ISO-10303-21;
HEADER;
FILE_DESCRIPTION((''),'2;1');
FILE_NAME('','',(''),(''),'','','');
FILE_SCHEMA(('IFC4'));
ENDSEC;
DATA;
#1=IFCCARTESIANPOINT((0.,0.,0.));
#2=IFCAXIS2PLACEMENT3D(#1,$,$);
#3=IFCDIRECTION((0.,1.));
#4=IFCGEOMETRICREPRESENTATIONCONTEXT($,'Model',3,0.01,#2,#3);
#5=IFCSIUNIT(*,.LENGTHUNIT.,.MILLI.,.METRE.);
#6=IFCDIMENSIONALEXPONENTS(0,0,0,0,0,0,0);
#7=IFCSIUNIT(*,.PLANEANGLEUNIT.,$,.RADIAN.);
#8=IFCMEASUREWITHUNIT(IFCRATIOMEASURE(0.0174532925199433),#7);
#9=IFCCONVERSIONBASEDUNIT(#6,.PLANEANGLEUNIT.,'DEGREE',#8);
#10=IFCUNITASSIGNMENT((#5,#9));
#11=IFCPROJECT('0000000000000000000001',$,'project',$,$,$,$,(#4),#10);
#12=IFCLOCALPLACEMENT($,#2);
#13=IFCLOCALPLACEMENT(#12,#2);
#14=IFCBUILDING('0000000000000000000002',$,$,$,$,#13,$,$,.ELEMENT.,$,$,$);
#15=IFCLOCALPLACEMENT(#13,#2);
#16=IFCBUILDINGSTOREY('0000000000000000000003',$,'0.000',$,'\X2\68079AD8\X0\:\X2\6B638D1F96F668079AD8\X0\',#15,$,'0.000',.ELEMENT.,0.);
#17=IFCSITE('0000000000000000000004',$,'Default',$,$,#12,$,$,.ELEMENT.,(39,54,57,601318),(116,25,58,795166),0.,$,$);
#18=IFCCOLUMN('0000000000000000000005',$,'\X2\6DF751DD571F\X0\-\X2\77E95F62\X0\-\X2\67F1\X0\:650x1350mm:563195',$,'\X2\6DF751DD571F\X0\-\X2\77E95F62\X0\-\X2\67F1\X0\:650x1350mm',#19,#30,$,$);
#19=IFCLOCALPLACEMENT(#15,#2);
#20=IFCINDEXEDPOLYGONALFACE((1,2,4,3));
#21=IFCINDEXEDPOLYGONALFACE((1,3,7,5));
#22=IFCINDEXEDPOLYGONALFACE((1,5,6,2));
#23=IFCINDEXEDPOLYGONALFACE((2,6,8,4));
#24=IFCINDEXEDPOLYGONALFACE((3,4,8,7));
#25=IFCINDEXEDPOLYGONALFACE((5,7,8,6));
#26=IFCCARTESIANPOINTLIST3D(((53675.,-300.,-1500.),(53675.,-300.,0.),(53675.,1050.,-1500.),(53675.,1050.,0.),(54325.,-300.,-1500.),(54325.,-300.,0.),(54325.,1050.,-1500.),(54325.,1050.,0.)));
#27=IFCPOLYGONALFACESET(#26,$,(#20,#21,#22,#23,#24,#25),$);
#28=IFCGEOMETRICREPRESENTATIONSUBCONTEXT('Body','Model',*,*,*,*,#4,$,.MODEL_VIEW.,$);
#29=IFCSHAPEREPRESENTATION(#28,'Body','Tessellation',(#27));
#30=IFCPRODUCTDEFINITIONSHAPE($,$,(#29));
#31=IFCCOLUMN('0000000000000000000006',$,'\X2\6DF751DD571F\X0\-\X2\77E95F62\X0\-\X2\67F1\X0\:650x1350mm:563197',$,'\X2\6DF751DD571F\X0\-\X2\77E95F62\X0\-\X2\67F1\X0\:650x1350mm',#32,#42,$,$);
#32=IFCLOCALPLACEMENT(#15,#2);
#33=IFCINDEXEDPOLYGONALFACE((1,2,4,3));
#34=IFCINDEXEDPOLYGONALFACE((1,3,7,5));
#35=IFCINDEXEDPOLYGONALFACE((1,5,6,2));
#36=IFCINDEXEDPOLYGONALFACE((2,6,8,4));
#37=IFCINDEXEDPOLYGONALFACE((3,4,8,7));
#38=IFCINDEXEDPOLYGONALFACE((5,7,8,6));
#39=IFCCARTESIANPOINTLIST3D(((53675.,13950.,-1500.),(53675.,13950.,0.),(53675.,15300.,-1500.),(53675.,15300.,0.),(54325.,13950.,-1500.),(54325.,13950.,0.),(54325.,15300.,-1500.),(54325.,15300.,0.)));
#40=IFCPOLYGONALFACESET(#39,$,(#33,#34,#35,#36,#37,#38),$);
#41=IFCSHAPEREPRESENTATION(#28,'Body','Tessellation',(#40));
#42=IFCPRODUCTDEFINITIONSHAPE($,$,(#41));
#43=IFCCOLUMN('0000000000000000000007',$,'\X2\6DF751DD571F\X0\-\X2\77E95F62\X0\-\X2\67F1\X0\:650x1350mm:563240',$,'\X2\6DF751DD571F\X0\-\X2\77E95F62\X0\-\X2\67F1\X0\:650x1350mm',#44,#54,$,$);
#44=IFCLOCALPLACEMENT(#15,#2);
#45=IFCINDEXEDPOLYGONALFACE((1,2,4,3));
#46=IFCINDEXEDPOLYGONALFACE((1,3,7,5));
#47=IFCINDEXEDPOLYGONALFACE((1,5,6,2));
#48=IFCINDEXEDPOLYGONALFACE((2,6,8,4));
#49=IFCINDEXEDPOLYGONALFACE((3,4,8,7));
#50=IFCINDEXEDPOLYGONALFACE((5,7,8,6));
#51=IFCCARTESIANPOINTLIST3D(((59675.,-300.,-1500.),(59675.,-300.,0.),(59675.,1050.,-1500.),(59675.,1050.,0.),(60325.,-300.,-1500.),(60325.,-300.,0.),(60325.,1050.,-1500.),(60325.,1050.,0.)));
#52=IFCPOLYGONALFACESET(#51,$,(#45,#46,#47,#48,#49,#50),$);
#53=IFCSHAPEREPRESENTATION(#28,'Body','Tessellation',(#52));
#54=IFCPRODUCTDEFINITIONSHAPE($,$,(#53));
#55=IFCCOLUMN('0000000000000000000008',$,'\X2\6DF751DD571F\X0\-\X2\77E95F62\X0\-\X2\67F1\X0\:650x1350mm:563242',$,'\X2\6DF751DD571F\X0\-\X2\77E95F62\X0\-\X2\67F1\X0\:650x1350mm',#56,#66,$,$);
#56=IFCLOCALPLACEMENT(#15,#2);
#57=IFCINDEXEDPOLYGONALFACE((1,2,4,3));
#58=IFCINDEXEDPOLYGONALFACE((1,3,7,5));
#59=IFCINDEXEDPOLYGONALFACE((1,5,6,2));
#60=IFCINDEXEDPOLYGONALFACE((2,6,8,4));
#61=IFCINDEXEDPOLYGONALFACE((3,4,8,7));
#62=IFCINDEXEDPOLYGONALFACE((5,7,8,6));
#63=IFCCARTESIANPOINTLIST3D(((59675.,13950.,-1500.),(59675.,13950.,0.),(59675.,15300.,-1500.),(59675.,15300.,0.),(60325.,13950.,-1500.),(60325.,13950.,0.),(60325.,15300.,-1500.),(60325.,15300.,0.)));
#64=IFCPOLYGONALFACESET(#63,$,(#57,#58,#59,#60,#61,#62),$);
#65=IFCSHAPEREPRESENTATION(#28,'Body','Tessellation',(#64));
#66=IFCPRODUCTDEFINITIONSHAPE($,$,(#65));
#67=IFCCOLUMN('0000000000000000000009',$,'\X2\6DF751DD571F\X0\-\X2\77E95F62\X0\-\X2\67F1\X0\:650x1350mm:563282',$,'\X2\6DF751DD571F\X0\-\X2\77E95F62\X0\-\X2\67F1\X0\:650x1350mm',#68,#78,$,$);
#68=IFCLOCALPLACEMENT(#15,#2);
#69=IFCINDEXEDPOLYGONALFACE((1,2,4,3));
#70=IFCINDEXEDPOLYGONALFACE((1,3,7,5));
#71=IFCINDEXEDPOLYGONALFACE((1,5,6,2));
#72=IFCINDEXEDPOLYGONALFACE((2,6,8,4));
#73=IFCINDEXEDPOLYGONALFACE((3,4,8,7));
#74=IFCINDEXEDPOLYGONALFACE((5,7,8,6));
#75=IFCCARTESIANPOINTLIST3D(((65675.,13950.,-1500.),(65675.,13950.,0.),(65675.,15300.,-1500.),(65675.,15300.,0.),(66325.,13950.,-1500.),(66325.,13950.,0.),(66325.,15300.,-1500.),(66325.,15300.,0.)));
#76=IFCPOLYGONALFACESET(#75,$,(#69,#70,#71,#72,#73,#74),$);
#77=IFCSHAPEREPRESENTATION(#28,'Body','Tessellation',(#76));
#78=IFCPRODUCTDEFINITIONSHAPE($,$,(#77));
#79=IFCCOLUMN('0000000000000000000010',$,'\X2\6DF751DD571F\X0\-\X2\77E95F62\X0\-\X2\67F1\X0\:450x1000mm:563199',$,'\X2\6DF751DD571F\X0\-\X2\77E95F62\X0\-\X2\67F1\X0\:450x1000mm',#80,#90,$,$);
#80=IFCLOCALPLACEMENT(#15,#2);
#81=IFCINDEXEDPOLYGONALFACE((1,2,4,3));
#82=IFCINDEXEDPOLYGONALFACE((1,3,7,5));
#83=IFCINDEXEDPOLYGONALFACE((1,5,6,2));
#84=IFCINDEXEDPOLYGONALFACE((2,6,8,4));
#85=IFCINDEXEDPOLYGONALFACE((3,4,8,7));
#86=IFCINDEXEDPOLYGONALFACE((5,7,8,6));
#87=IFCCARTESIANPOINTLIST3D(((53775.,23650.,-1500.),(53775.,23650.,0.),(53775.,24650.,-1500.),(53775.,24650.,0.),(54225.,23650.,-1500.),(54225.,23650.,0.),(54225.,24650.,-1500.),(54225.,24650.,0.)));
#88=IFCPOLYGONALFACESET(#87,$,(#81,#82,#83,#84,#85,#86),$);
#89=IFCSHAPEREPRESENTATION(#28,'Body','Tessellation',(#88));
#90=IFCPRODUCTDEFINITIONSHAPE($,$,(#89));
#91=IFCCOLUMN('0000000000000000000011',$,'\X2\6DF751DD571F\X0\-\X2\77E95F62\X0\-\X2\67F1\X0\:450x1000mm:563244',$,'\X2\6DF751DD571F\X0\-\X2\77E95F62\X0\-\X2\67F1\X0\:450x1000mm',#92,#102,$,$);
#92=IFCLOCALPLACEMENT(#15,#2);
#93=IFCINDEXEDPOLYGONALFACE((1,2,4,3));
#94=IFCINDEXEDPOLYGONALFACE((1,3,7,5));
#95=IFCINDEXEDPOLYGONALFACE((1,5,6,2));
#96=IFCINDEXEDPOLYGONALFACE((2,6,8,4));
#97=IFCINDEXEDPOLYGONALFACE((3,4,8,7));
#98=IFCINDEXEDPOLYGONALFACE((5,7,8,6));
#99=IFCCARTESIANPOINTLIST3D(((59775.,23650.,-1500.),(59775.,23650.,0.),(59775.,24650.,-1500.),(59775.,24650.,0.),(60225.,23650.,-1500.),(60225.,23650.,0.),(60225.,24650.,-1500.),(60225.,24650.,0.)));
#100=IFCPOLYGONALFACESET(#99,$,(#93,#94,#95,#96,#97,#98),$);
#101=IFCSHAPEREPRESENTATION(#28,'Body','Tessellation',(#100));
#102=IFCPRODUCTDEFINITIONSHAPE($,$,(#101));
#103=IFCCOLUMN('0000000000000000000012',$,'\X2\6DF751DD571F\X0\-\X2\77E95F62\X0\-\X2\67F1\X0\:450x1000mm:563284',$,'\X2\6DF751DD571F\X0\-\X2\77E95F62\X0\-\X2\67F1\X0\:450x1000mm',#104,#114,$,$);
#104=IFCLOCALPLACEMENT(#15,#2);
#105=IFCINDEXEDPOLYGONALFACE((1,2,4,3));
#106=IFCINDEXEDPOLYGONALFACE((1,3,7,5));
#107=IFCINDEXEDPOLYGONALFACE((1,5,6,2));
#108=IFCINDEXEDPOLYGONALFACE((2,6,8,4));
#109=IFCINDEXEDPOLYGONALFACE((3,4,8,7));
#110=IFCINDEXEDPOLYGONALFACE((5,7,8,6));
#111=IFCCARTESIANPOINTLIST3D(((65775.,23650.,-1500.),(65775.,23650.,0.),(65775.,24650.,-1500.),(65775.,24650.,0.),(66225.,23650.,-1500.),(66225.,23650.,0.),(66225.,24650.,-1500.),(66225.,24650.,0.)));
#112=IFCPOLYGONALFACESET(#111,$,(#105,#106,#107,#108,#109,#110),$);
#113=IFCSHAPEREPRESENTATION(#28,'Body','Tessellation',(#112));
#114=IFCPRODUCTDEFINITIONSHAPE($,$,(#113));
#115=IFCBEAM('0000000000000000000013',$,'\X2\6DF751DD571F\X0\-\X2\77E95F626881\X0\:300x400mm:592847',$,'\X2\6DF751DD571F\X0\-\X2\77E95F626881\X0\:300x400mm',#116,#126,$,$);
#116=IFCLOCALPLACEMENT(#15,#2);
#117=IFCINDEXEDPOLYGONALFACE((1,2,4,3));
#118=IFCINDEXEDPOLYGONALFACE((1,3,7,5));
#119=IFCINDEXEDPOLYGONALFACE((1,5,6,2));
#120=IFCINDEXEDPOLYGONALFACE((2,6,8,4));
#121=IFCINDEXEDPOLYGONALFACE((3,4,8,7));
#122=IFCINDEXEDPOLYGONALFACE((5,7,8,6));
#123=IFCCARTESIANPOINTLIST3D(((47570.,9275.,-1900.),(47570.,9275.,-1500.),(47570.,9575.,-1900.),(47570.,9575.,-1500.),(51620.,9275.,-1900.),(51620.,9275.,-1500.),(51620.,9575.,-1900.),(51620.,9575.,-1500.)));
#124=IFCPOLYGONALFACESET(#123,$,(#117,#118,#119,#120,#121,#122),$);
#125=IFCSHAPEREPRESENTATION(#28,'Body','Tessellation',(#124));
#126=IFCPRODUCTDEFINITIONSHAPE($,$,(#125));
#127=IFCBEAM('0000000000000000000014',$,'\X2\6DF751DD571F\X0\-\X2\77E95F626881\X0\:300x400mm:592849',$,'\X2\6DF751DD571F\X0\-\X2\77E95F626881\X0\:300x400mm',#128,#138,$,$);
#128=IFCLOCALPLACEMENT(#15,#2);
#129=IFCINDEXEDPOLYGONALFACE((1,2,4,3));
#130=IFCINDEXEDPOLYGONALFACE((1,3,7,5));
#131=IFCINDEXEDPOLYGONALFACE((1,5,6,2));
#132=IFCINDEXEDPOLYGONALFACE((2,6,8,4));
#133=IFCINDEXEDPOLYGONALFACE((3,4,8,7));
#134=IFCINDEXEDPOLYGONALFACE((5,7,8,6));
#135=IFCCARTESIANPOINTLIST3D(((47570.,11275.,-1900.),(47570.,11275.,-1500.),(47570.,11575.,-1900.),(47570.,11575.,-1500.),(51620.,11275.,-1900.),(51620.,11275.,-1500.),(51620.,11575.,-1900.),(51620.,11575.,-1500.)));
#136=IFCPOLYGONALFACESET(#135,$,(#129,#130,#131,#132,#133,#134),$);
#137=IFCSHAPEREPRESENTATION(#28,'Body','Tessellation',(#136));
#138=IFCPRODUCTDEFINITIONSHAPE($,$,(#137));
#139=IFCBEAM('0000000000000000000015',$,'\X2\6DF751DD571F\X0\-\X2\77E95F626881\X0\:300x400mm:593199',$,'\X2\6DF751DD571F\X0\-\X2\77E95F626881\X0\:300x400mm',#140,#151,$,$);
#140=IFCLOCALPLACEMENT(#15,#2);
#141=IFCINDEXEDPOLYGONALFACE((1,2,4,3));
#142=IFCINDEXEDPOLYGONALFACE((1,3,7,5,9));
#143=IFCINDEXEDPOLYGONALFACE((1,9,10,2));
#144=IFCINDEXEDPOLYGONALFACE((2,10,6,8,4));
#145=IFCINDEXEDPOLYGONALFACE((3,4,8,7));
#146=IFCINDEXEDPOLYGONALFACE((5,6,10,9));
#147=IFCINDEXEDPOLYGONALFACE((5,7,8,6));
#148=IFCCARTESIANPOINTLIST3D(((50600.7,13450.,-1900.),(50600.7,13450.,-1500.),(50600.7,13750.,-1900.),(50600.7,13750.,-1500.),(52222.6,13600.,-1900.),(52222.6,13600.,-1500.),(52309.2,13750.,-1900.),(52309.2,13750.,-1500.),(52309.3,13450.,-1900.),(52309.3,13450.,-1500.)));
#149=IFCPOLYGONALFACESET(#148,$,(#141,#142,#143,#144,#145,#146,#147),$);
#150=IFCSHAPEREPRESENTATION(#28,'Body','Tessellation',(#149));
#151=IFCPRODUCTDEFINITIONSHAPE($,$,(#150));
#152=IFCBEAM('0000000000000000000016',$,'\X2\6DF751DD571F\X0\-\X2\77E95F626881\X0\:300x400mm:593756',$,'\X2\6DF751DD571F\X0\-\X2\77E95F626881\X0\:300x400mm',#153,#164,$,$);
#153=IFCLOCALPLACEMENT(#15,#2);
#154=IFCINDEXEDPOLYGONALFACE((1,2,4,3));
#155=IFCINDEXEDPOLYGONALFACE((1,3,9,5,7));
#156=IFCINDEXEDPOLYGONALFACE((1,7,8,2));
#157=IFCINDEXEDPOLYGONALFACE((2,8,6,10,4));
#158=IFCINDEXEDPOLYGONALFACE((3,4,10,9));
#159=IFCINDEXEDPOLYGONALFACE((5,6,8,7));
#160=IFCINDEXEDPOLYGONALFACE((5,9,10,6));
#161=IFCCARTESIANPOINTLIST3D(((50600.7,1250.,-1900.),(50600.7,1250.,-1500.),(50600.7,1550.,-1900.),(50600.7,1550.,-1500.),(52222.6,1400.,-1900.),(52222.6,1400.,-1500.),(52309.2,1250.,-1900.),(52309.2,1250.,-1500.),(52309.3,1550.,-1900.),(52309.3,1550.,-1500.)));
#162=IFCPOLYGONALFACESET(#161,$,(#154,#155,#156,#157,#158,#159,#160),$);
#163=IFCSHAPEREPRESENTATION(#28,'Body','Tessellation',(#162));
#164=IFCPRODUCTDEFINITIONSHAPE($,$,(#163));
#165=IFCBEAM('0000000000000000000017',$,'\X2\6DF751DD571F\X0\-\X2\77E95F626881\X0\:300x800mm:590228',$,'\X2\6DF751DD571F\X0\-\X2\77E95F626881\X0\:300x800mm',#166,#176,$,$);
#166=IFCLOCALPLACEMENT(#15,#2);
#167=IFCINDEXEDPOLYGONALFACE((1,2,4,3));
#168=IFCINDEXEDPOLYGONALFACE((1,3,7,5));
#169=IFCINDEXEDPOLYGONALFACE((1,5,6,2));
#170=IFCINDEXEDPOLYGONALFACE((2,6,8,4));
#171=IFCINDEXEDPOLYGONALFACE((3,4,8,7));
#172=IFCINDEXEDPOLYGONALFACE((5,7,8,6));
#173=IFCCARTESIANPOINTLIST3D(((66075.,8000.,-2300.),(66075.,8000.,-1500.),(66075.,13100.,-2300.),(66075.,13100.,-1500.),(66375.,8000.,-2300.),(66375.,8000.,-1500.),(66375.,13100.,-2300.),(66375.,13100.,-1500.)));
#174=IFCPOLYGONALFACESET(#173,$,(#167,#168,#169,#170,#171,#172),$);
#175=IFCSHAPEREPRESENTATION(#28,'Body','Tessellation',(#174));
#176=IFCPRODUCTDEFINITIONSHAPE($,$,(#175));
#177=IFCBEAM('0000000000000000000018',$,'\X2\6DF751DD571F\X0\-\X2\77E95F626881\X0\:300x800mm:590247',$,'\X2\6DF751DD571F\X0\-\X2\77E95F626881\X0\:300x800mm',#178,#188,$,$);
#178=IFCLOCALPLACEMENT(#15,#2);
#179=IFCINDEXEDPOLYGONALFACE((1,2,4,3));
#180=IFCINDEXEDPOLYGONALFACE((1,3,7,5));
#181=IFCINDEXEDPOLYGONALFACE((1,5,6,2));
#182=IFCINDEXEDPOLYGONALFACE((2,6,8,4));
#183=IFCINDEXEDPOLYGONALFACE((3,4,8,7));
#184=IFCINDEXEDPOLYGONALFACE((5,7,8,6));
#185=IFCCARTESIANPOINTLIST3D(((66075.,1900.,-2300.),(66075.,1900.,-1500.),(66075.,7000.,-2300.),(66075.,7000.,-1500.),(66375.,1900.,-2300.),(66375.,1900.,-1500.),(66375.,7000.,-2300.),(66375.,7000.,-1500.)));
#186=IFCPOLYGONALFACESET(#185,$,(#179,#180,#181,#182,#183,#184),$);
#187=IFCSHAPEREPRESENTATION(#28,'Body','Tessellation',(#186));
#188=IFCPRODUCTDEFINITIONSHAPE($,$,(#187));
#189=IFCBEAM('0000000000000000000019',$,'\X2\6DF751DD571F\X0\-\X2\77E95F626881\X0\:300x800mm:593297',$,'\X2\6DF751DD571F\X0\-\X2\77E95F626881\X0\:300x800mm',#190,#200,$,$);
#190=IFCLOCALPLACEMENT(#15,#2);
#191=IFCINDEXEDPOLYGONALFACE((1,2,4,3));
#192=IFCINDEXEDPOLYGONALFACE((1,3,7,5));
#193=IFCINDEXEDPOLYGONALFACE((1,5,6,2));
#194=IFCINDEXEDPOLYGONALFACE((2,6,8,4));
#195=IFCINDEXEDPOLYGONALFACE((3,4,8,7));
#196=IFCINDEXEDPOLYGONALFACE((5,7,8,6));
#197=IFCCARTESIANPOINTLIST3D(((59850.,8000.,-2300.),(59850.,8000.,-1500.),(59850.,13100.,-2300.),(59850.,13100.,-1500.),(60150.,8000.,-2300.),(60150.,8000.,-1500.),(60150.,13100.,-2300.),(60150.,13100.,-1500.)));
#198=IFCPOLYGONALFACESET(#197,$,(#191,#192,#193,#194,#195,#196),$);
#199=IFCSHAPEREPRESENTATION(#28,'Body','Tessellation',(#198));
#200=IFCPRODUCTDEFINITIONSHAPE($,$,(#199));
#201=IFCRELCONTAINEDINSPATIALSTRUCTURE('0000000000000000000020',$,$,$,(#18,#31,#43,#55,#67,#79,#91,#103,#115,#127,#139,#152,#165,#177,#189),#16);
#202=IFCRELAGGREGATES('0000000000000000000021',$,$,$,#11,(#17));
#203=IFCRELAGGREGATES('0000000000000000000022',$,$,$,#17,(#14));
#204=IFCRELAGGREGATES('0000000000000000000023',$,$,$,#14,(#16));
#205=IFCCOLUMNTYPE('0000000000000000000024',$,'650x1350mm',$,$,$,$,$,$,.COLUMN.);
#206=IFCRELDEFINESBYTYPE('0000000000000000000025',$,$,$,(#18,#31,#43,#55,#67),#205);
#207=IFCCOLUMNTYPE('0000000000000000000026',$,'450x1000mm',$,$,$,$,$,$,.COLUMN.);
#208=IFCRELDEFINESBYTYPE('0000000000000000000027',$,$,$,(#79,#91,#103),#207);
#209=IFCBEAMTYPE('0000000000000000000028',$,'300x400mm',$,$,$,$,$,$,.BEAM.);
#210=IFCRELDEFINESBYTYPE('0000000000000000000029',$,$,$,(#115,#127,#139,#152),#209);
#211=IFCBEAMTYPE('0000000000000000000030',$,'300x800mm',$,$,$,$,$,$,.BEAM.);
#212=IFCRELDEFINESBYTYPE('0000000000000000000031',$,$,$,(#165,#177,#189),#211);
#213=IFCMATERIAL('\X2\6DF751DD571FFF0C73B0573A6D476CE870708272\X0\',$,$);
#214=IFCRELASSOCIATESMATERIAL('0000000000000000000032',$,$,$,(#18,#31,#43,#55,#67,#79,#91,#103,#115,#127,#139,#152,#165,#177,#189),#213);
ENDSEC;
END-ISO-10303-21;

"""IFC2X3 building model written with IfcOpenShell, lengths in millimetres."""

from ifc_helpers import new_model, entity, si_unit, converted_unit, direction, frame, frame_2d, origin, origin_2d_with_axis, place, context, subcontext, project, spatial, polyline, rectangle, extrude, clip, bounded_halfspace, source, transform, mapped, material, type_object, type_shapes, element, save


model = new_model("IFC2X3")

# Units and contexts
model_context = context("Model", 3, precision=0.01, world=origin(), true_north=direction((0.0, 1.0)))
body_context = subcontext(model_context, "Body", "Model", "MODEL_VIEW")
ifc_project = project(units=[si_unit("LENGTHUNIT", "METRE", prefix="MILLI"), converted_unit("PLANEANGLEUNIT", "DEGREE", entity("IfcRatioMeasure", 0.0174532925199433), si_unit("PLANEANGLEUNIT", "RADIAN"), dimensions=[0, 0, 0, 0, 0, 0, 0])], contexts=[model_context])

# Site, building, storey
site_placement = place(None, origin())
site = spatial("IfcSite", under=ifc_project, at=site_placement, Name="Default", CompositionType="ELEMENT", RefLatitude=(39, 54, 57, 601318), RefLongitude=(116, 25, 58, 795166), RefElevation=0.0)
building_placement = place(site_placement, origin())
building = spatial("IfcBuilding", under=site, at=building_placement, CompositionType="ELEMENT")
storey_placement = place(building_placement, origin())
storey = spatial("IfcBuildingStorey", under=building, at=storey_placement, Name="0.000", ObjectType="标高:正负零标高", LongName="0.000", CompositionType="ELEMENT", Elevation=0.0)

# Columns
ifc_material = material(Name="混凝土，现场浇注灰色")
column_type_1 = type_object("IfcColumnType", Name="650x1350mm", PredefinedType="COLUMN")
shared_shape_1 = source(origin(), body_context, "Body", "SweptSolid", [
    extrude(rectangle(XDim=1350.0, YDim=650.0, at=origin_2d_with_axis()), frame((0.0, 0.0, -1500.0), z_axis=(0.0, 0.0, 1.0), x_axis=(0.0, -1.0, 0.0)), (0.0, 0.0, 1.0), 1500.0),
])
type_shapes(column_type_1, [shared_shape_1])
for number, where, name in (
    (1, (54000.0, 375.0, 0.0), "混凝土-矩形-柱:650x1350mm:563195"),
    (2, (54000.0, 14625.0, 0.0), "混凝土-矩形-柱:650x1350mm:563197"),
    (3, (60000.0, 375.0, 0.0), "混凝土-矩形-柱:650x1350mm:563240"),
    (4, (60000.0, 14625.0, 0.0), "混凝土-矩形-柱:650x1350mm:563242"),
    (5, (66000.0, 14625.0, 0.0), "混凝土-矩形-柱:650x1350mm:563282"),
):
    element("IfcColumn", number, at=place(storey_placement, frame(where)), inside=storey, type_object=column_type_1, material=ifc_material, Name=name, ObjectType="混凝土-矩形-柱:650x1350mm", context=body_context, shape_type="MappedRepresentation", body=[
        mapped(shared_shape_1, transform((0.0, 0.0, 0.0), scale=1.0)),
    ])
column_type_2 = type_object("IfcColumnType", Name="450x1000mm", PredefinedType="COLUMN")
shared_shape_2 = source(origin(), body_context, "Body", "SweptSolid", [
    extrude(rectangle(XDim=1000.0, YDim=450.0, at=origin_2d_with_axis()), frame((0.0, 0.0, -1500.0), z_axis=(0.0, 0.0, 1.0), x_axis=(0.0, -1.0, 0.0)), (0.0, 0.0, 1.0), 1500.0),
])
type_shapes(column_type_2, [shared_shape_2])
for number, where, name in (
    (6, (54000.0, 24150.0, 0.0), "混凝土-矩形-柱:450x1000mm:563199"),
    (7, (60000.0, 24150.0, 0.0), "混凝土-矩形-柱:450x1000mm:563244"),
    (8, (66000.0, 24150.0, 0.0), "混凝土-矩形-柱:450x1000mm:563284"),
):
    element("IfcColumn", number, at=place(storey_placement, frame(where)), inside=storey, type_object=column_type_2, material=ifc_material, Name=name, ObjectType="混凝土-矩形-柱:450x1000mm", context=body_context, shape_type="MappedRepresentation", body=[
        mapped(shared_shape_2, transform((0.0, 0.0, 0.0), scale=1.0)),
    ])

# Beams
beam_type_1 = type_object("IfcBeamType", Name="300x400mm", PredefinedType="BEAM")
beam_1_placement = place(storey_placement, frame((51620.0, 9425.0, -1500.0), z_axis=(0.0, 0.0, 1.0), x_axis=(-1.0, 0.0, 0.0)))
element("IfcBeam", 9, at=beam_1_placement, inside=storey, type_object=beam_type_1, material=ifc_material, Name="混凝土-矩形梁:300x400mm:592847", ObjectType="混凝土-矩形梁:300x400mm", context=body_context, shape_type="SweptSolid", body=[
    extrude(rectangle(XDim=400.0, YDim=300.0, at=frame_2d((0.0, 0.0), x_axis=(1.0, 0.0))), frame((0.0, 0.0, -200.0), z_axis=(1.0, 0.0, 0.0), x_axis=(0.0, 0.0, -1.0)), (0.0, 0.0, 1.0), 4050.0),
])
beam_2_placement = place(storey_placement, frame((51620.0, 11425.0, -1500.0), z_axis=(0.0, 0.0, 1.0), x_axis=(-1.0, 0.0, 0.0)))
element("IfcBeam", 10, at=beam_2_placement, inside=storey, type_object=beam_type_1, material=ifc_material, Name="混凝土-矩形梁:300x400mm:592849", ObjectType="混凝土-矩形梁:300x400mm", context=body_context, shape_type="SweptSolid", body=[
    extrude(rectangle(XDim=400.0, YDim=300.0, at=frame_2d((0.0, 0.0), x_axis=(1.0, 0.0))), frame((0.0, 0.0, -200.0), z_axis=(1.0, 0.0, 0.0), x_axis=(0.0, 0.0, -1.0)), (0.0, 0.0, 1.0), 4050.0),
])
beam_3_placement = place(storey_placement, frame((52380.0, 13600.0, -1500.0), z_axis=(0.0, 0.0, 1.0), x_axis=(-1.0, 0.0, 0.0)))
element("IfcBeam", 11, at=beam_3_placement, inside=storey, type_object=beam_type_1, material=ifc_material, Name="混凝土-矩形梁:300x400mm:593199", ObjectType="混凝土-矩形梁:300x400mm", context=body_context, shape_type="Clipping", body=[
    clip(clip(extrude(rectangle(XDim=400.0, YDim=300.0, at=frame_2d((0.0, 0.0), x_axis=(1.0, 0.0))), frame((70.7, 0.0, -200.0), z_axis=(1.0, 0.0, 0.0), x_axis=(0.0, 0.0, -1.0)), (0.0, 0.0, 1.0), 1708.5), bounded_halfspace(frame((-1331.4, -2578.0, 0.0), z_axis=(-0.865977, 0.500083, 0.0), x_axis=(0.0, 0.0, -1.0)), False, frame((70.7, 0.0, -200.0), z_axis=(1.0, 0.0, 0.0), x_axis=(0.0, 0.0, -1.0)), polyline([(-200.0, 0.0), (200.0, 0.0), (200.0, -150.0), (-200.0, -150.0), (-200.0, 0.0)]))), bounded_halfspace(frame((157.4, 0.0, 0.0), z_axis=(-0.866025, -0.5, 0.0), x_axis=(0.0, 0.0, -1.0)), False, frame((70.7, 0.0, -200.0), z_axis=(1.0, 0.0, 0.0), x_axis=(0.0, 0.0, -1.0)), polyline([(200.0, 0.0), (-200.0, 0.0), (-200.0, 150.0), (200.0, 150.0), (200.0, 0.0)]))),
])
beam_4_placement = place(storey_placement, frame((50100.0, 1400.0, -1500.0)))
element("IfcBeam", 12, at=beam_4_placement, inside=storey, type_object=beam_type_1, material=ifc_material, Name="混凝土-矩形梁:300x400mm:593756", ObjectType="混凝土-矩形梁:300x400mm", context=body_context, shape_type="Clipping", body=[
    clip(clip(extrude(rectangle(XDim=400.0, YDim=300.0, at=frame_2d((0.0, 0.0), x_axis=(1.0, 0.0))), frame((500.7, 0.0, -200.0), z_axis=(1.0, 0.0, 0.0), x_axis=(0.0, 0.0, -1.0)), (0.0, 0.0, 1.0), 1708.5), bounded_halfspace(frame((3611.4, -2578.0, 0.0), z_axis=(0.865977, 0.500083, 0.0), x_axis=(0.0, 0.0, -1.0)), False, frame((500.7, 0.0, -200.0), z_axis=(1.0, 0.0, 0.0), x_axis=(0.0, 0.0, -1.0)), polyline([(200.0, 0.0), (-200.0, 0.0), (-200.0, -150.0), (200.0, -150.0), (200.0, 0.0)]))), bounded_halfspace(frame((2122.6, 0.0, 0.0), z_axis=(0.866025, -0.5, 0.0), x_axis=(0.0, 0.0, -1.0)), False, frame((500.7, 0.0, -200.0), z_axis=(1.0, 0.0, 0.0), x_axis=(0.0, 0.0, -1.0)), polyline([(-200.0, 0.0), (200.0, 0.0), (200.0, 150.0), (-200.0, 150.0), (-200.0, 0.0)]))),
])
beam_type_2 = type_object("IfcBeamType", Name="300x800mm", PredefinedType="BEAM")
beam_5_placement = place(storey_placement, frame((66225.0, 13100.0, -1500.0), z_axis=(0.0, 0.0, 1.0), x_axis=(0.0, -1.0, 0.0)))
element("IfcBeam", 13, at=beam_5_placement, inside=storey, type_object=beam_type_2, material=ifc_material, Name="混凝土-矩形梁:300x800mm:590228", ObjectType="混凝土-矩形梁:300x800mm", context=body_context, shape_type="SweptSolid", body=[
    extrude(rectangle(XDim=800.0, YDim=300.0, at=frame_2d((0.0, 0.0), x_axis=(1.0, 0.0))), frame((0.0, 0.0, -400.0), z_axis=(1.0, 0.0, 0.0), x_axis=(0.0, 0.0, -1.0)), (0.0, 0.0, 1.0), 5100.0),
])
beam_6_placement = place(storey_placement, frame((66225.0, 7000.0, -1500.0), z_axis=(0.0, 0.0, 1.0), x_axis=(0.0, -1.0, 0.0)))
element("IfcBeam", 14, at=beam_6_placement, inside=storey, type_object=beam_type_2, material=ifc_material, Name="混凝土-矩形梁:300x800mm:590247", ObjectType="混凝土-矩形梁:300x800mm", context=body_context, shape_type="SweptSolid", body=[
    extrude(rectangle(XDim=800.0, YDim=300.0, at=frame_2d((0.0, 0.0), x_axis=(1.0, 0.0))), frame((0.0, 0.0, -400.0), z_axis=(1.0, 0.0, 0.0), x_axis=(0.0, 0.0, -1.0)), (0.0, 0.0, 1.0), 5100.0),
])
beam_7_placement = place(storey_placement, frame((60000.0, 13100.0, -1500.0), z_axis=(0.0, 0.0, 1.0), x_axis=(0.0, -1.0, 0.0)))
element("IfcBeam", 15, at=beam_7_placement, inside=storey, type_object=beam_type_2, material=ifc_material, Name="混凝土-矩形梁:300x800mm:593297", ObjectType="混凝土-矩形梁:300x800mm", context=body_context, shape_type="SweptSolid", body=[
    extrude(rectangle(XDim=800.0, YDim=300.0, at=frame_2d((0.0, 0.0), x_axis=(1.0, 0.0))), frame((0.0, 0.0, -400.0), z_axis=(1.0, 0.0, 0.0), x_axis=(0.0, 0.0, -1.0)), (0.0, 0.0, 1.0), 5100.0),
])

save(model, "model.ifc")
